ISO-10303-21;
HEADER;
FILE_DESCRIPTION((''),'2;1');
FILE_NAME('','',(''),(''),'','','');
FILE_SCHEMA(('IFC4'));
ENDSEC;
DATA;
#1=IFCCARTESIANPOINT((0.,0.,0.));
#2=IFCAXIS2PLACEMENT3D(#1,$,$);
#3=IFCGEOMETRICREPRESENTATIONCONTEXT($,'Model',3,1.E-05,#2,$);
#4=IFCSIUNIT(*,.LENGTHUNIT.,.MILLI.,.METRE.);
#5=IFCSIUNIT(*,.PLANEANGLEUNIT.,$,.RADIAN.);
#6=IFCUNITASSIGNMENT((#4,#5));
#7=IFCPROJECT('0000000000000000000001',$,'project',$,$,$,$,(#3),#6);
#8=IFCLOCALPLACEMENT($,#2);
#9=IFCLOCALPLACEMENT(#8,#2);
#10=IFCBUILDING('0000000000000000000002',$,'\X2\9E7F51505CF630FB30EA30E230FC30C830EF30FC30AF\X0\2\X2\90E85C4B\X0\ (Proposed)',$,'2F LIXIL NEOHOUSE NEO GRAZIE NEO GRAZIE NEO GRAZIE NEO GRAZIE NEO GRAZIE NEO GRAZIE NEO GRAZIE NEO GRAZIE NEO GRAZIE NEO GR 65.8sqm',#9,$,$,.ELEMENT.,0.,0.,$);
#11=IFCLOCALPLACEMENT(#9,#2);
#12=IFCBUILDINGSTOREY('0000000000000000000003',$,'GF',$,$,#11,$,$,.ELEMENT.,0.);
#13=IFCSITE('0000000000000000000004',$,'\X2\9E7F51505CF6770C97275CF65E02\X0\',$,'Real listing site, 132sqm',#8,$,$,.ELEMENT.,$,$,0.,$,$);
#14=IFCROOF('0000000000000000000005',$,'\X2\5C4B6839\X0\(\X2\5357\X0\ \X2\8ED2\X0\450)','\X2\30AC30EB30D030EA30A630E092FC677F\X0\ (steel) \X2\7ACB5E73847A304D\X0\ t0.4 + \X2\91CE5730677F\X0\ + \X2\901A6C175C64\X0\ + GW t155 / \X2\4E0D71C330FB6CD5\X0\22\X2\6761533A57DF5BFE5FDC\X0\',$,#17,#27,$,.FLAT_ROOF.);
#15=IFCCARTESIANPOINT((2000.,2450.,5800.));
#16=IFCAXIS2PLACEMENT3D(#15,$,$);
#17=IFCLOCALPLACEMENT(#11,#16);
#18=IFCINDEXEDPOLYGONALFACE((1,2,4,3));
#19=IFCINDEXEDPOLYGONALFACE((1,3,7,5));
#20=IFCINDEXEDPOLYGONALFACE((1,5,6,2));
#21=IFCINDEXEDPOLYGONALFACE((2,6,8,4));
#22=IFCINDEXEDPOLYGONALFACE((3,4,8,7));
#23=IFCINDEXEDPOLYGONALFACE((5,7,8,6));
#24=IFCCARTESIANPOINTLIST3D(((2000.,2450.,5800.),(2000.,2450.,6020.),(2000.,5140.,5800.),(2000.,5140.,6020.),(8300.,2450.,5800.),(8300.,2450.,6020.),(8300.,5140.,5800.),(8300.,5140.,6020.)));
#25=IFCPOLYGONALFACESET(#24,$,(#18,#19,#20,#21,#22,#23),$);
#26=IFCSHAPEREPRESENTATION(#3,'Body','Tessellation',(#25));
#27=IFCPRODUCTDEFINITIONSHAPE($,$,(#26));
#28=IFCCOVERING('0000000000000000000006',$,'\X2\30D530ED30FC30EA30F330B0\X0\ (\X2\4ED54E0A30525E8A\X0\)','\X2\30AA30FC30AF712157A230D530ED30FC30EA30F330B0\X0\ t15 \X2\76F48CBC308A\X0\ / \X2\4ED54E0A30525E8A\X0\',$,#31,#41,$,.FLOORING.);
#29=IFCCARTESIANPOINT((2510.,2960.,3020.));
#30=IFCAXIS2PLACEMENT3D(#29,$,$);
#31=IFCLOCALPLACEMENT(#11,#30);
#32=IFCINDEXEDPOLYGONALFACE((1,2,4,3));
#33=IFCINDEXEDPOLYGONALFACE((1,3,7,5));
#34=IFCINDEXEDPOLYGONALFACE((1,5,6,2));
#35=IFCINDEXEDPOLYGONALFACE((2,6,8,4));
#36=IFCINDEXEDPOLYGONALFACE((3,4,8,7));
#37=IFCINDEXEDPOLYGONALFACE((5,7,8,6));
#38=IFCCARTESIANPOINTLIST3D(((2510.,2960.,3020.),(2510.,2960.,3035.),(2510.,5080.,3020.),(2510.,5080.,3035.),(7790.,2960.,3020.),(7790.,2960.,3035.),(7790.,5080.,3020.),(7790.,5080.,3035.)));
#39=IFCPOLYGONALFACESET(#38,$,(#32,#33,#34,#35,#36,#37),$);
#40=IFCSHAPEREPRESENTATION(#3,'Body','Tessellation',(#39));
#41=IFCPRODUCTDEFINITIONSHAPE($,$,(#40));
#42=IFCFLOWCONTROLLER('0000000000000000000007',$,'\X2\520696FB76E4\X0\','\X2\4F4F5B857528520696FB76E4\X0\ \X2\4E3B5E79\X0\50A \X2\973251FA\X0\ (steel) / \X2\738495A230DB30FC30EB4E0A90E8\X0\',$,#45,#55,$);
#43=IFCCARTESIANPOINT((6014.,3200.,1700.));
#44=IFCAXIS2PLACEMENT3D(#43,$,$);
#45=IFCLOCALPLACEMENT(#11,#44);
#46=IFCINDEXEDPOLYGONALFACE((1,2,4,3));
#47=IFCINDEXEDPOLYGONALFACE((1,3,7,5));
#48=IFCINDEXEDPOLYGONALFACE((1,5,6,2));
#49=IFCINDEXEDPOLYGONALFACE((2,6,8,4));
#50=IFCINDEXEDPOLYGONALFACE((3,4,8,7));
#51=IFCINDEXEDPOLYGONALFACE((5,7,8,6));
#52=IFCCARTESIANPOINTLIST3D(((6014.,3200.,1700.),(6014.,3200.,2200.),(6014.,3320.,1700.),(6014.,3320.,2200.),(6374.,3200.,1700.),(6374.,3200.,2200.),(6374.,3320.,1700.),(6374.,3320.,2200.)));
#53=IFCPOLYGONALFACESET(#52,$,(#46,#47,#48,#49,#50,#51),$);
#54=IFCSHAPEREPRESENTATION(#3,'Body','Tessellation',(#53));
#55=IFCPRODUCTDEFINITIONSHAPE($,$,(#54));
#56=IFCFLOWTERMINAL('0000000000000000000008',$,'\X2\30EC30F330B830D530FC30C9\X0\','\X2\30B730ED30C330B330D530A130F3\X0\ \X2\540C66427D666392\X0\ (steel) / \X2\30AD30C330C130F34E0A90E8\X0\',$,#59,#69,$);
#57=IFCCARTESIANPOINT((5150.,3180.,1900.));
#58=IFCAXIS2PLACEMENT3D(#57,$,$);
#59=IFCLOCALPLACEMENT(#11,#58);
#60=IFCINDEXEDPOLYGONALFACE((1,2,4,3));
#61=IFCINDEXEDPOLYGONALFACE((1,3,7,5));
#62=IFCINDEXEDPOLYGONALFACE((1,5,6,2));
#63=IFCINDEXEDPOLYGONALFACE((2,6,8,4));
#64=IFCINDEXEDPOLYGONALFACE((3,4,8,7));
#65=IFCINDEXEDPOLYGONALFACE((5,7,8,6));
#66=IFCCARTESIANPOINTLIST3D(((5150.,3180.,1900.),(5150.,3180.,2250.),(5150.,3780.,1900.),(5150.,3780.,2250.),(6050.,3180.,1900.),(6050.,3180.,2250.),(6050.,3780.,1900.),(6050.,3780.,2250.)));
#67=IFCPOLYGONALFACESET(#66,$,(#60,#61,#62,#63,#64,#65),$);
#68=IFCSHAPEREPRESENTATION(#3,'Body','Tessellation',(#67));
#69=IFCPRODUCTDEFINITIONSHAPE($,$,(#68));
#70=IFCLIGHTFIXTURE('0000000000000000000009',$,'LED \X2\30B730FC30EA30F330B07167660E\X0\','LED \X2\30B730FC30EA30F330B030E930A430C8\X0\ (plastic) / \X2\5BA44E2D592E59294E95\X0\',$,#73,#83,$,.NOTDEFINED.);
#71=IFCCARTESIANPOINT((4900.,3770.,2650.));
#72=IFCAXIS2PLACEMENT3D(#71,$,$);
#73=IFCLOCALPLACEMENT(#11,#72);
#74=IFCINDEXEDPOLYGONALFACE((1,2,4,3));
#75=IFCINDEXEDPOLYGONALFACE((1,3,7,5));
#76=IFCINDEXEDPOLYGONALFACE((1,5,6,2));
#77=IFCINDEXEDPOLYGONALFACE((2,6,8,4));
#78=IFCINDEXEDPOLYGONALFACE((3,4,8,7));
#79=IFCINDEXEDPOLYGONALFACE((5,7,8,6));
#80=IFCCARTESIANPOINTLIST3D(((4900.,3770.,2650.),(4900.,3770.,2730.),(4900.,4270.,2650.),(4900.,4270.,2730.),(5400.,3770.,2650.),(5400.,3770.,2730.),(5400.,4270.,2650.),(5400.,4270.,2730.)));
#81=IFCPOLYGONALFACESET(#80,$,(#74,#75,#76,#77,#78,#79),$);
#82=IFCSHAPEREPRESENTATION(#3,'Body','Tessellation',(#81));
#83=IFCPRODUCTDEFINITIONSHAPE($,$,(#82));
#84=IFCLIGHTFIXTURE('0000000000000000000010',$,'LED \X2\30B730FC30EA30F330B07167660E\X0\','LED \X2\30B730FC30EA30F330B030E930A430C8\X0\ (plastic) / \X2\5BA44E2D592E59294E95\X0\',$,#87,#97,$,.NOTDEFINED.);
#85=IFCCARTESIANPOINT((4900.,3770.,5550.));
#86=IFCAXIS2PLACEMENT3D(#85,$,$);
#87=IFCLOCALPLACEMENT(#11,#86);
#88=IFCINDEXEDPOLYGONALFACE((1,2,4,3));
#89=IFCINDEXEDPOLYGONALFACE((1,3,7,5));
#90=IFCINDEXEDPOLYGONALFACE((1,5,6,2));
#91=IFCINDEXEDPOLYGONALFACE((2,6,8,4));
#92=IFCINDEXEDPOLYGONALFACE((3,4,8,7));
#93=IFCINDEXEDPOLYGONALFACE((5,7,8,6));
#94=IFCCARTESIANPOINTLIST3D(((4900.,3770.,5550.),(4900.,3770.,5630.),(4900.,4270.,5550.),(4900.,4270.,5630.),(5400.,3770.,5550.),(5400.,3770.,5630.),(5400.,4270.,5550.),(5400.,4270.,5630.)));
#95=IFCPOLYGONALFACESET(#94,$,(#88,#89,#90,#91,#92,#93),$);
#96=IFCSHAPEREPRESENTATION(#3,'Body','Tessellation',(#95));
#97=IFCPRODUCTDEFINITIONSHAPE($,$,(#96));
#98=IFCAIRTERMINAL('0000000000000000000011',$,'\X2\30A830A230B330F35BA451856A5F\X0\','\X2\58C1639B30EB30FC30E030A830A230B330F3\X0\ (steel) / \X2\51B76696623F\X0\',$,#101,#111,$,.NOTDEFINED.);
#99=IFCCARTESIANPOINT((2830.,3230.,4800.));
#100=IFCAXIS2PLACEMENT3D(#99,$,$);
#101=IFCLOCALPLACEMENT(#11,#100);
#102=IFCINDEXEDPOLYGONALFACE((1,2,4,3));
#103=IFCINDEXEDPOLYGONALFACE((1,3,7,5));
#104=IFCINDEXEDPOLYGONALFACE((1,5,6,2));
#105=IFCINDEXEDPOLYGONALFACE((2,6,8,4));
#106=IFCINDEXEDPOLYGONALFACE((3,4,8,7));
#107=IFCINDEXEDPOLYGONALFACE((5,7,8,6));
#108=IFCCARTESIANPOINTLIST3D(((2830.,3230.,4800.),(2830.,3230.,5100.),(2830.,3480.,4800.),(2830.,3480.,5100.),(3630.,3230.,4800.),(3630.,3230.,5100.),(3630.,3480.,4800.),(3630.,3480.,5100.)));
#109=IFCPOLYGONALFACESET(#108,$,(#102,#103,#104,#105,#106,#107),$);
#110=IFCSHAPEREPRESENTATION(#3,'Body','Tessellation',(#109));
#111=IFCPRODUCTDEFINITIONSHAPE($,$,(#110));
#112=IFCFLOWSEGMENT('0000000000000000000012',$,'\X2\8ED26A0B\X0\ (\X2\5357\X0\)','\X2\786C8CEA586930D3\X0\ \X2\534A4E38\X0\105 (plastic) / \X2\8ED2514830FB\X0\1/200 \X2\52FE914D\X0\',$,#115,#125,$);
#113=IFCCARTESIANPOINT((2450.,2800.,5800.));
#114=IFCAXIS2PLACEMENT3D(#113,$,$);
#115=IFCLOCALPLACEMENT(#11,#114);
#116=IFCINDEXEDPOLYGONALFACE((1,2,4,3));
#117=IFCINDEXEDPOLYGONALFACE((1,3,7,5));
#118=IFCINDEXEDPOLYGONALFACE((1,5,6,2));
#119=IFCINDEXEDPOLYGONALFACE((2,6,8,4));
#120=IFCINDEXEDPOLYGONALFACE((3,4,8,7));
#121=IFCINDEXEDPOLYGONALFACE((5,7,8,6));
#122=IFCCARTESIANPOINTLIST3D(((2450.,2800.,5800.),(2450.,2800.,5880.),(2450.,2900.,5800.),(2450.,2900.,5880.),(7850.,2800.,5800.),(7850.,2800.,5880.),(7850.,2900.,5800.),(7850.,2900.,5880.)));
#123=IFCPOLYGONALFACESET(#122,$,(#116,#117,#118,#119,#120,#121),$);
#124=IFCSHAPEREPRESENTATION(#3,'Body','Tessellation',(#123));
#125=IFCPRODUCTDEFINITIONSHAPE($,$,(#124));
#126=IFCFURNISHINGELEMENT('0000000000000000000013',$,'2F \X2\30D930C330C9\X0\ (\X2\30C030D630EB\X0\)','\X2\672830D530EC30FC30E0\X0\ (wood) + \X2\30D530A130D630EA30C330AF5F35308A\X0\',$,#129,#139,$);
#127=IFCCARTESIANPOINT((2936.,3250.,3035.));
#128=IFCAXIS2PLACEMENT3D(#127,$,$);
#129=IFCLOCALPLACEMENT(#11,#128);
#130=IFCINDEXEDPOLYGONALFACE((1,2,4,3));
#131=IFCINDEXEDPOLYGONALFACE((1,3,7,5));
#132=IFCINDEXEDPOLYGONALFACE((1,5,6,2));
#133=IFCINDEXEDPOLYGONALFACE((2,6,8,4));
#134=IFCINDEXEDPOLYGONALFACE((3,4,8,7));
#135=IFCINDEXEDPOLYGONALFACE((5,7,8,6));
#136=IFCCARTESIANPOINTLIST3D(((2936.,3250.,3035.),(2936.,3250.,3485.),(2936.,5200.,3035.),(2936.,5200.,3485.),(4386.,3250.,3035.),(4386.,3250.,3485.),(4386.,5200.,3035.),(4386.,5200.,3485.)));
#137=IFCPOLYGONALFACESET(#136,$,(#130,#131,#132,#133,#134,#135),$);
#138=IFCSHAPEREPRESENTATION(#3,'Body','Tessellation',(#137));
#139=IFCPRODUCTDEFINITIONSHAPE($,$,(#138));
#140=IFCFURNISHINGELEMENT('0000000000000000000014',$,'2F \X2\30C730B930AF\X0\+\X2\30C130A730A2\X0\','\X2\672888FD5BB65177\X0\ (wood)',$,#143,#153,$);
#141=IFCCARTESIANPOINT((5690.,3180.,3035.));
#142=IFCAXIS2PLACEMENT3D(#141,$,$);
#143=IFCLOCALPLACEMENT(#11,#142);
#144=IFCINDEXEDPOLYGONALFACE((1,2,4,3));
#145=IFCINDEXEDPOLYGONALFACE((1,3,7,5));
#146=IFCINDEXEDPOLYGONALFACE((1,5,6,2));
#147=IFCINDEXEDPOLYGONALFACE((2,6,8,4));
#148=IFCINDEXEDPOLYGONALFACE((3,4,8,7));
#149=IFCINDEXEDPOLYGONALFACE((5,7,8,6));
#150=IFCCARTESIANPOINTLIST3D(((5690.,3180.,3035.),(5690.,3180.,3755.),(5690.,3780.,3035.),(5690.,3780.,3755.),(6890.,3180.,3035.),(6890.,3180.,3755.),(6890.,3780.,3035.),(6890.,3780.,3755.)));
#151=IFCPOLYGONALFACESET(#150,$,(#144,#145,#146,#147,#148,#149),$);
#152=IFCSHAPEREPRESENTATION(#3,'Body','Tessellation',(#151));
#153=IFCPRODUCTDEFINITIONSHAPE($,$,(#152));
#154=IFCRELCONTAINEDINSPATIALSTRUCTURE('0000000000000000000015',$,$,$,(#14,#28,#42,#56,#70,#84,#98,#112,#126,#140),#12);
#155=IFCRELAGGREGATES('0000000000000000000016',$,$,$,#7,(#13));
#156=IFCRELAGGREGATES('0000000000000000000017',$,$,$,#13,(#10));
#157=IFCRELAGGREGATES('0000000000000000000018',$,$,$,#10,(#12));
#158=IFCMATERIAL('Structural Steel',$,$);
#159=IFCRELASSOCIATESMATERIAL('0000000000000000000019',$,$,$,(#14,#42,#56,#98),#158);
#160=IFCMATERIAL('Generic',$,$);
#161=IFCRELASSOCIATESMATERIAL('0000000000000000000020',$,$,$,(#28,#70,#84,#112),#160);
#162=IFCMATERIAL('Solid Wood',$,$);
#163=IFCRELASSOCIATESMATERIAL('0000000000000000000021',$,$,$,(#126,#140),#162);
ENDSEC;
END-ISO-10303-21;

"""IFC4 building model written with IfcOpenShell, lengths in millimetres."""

from ifc_helpers import new_model, si_unit, frame, frame_2d, origin, place, context, project, spatial, rectangle, extrude, material, element, save


model = new_model("IFC4")

# Units and contexts
model_context = context("Model", 3, precision=1e-05, world=origin())
ifc_project = project(units=[si_unit("LENGTHUNIT", "METRE", prefix="MILLI"), si_unit("PLANEANGLEUNIT", "RADIAN")], contexts=[model_context])

# Site, building, storey
site_placement = place(None, origin())
site = spatial("IfcSite", under=ifc_project, at=site_placement, Name="鹿児島県霧島市", ObjectType="Real listing site, 132sqm", CompositionType="ELEMENT", RefElevation=0.0)
building_placement = place(site_placement, origin())
building = spatial("IfcBuilding", under=site, at=building_placement, Name="鹿児島・リモートワーク2部屋 (Proposed)", ObjectType="2F LIXIL NEOHOUSE NEO GRAZIE NEO GRAZIE NEO GRAZIE NEO GRAZIE NEO GRAZIE NEO GRAZIE NEO GRAZIE NEO GRAZIE NEO GRAZIE NEO GR 65.8sqm", CompositionType="ELEMENT", ElevationOfRefHeight=0.0, ElevationOfTerrain=0.0)
storey_placement = place(building_placement, origin())
storey = spatial("IfcBuildingStorey", under=building, at=storey_placement, Name="GF", CompositionType="ELEMENT", Elevation=0.0)

# Shared definitions
ifc_material_1 = material(Name="Solid Wood")

# Roof
ifc_material_2 = material(Name="Structural Steel")
for number, where, name in (
    (1, (2000.0, 2450.0, 5800.0), "屋根(南 軒450)"),
):
    element("IfcRoof", number, at=place(storey_placement, frame(where)), inside=storey, material=ifc_material_2, Name=name, Description="ガルバリウム鋼板 (steel) 立平葺き t0.4 + 野地板 + 通気層 + GW t155 / 不燃・法22条区域対応", PredefinedType="FLAT_ROOF", context=model_context, shape_type="SweptSolid", body=[
        extrude(rectangle(XDim=6300.0, YDim=2690.0, at=frame_2d((3150.0, 1345.0))), frame((2000.0, 2450.0, 5800.0)), (0.0, 0.0, 1.0), 220.0),
    ])

# Covering
ifc_material_3 = material(Name="Generic")
covering_placement = place(storey_placement, frame((2510.0, 2960.0, 3020.0)))
element("IfcCovering", 2, at=covering_placement, inside=storey, material=ifc_material_3, Name="フローリング (仕上げ床)", Description="オーク無垢フローリング t15 直貼り / 仕上げ床", PredefinedType="FLOORING", context=model_context, shape_type="SweptSolid", body=[
    extrude(rectangle(XDim=5280.0, YDim=2120.0, at=frame_2d((2640.0, 1060.0))), frame((2510.0, 2960.0, 3020.0)), (0.0, 0.0, 1.0), 15.0),
])

# Flow controller
flow_controller_placement = place(storey_placement, frame((6014.0, 3200.0, 1700.0)))
element("IfcFlowController", 3, at=flow_controller_placement, inside=storey, material=ifc_material_2, Name="分電盤", Description="住宅用分電盤 主幹50A 露出 (steel) / 玄関ホール上部", context=model_context, shape_type="SweptSolid", body=[
    extrude(rectangle(XDim=360.0, YDim=120.0, at=frame_2d((180.0, 60.0))), frame((6014.0, 3200.0, 1700.0)), (0.0, 0.0, 1.0), 500.0),
])

# Flow terminal
flow_terminal_placement = place(storey_placement, frame((5150.0, 3180.0, 1900.0)))
element("IfcFlowTerminal", 4, at=flow_terminal_placement, inside=storey, material=ifc_material_2, Name="レンジフード", Description="シロッコファン 同時給排 (steel) / キッチン上部", context=model_context, shape_type="SweptSolid", body=[
    extrude(rectangle(XDim=900.0, YDim=600.0, at=frame_2d((450.0, 300.0))), frame((5150.0, 3180.0, 1900.0)), (0.0, 0.0, 1.0), 350.0),
])

# Light fixtures
light_fixture_1_placement = place(storey_placement, frame((4900.0, 3770.0, 2650.0)))
element("IfcLightFixture", 5, at=light_fixture_1_placement, inside=storey, material=ifc_material_3, Name="LED シーリング照明", Description="LED シーリングライト (plastic) / 室中央天井", PredefinedType="NOTDEFINED", context=model_context, shape_type="SweptSolid", body=[
    extrude(rectangle(XDim=500.0, YDim=500.0, at=frame_2d((250.0, 250.0))), frame((4900.0, 3770.0, 2650.0)), (0.0, 0.0, 1.0), 80.0),
])
light_fixture_2_placement = place(storey_placement, frame((4900.0, 3770.0, 5550.0)))
element("IfcLightFixture", 6, at=light_fixture_2_placement, inside=storey, material=ifc_material_3, Name="LED シーリング照明", Description="LED シーリングライト (plastic) / 室中央天井", PredefinedType="NOTDEFINED", context=model_context, shape_type="SweptSolid", body=[
    extrude(rectangle(XDim=500.0, YDim=500.0, at=frame_2d((250.0, 250.0))), frame((4900.0, 3770.0, 5550.0)), (0.0, 0.0, 1.0), 80.0),
])

# Air terminal
air_terminal_placement = place(storey_placement, frame((2830.0, 3230.0, 4800.0)))
element("IfcAirTerminal", 7, at=air_terminal_placement, inside=storey, material=ifc_material_2, Name="エアコン室内機", Description="壁掛ルームエアコン (steel) / 冷暖房", PredefinedType="NOTDEFINED", context=model_context, shape_type="SweptSolid", body=[
    extrude(rectangle(XDim=800.0, YDim=250.0, at=frame_2d((400.0, 125.0))), frame((2830.0, 3230.0, 4800.0)), (0.0, 0.0, 1.0), 300.0),
])

# Flow segment
flow_segment_placement = place(storey_placement, frame((2450.0, 2800.0, 5800.0)))
element("IfcFlowSegment", 8, at=flow_segment_placement, inside=storey, material=ifc_material_3, Name="軒樋 (南)", Description="硬質塩ビ 半丸105 (plastic) / 軒先・1/200 勾配", context=model_context, shape_type="SweptSolid", body=[
    extrude(rectangle(XDim=5400.0, YDim=100.0, at=frame_2d((2700.0, 50.0))), frame((2450.0, 2800.0, 5800.0)), (0.0, 0.0, 1.0), 80.0),
])

# Furnishing elements
furnishing_1_placement = place(storey_placement, frame((2936.0, 3250.0, 3035.0)))
element("IfcFurnishingElement", 9, at=furnishing_1_placement, inside=storey, material=ifc_material_1, Name="2F ベッド (ダブル)", Description="木フレーム (wood) + ファブリック張り", context=model_context, shape_type="SweptSolid", body=[
    extrude(rectangle(XDim=1450.0, YDim=1950.0, at=frame_2d((725.0, 975.0))), frame((2936.0, 3250.0, 3035.0)), (0.0, 0.0, 1.0), 450.0),
])
furnishing_2_placement = place(storey_placement, frame((5690.0, 3180.0, 3035.0)))
element("IfcFurnishingElement", 10, at=furnishing_2_placement, inside=storey, material=ifc_material_1, Name="2F デスク+チェア", Description="木製家具 (wood)", context=model_context, shape_type="SweptSolid", body=[
    extrude(rectangle(XDim=1200.0, YDim=600.0, at=frame_2d((600.0, 300.0))), frame((5690.0, 3180.0, 3035.0)), (0.0, 0.0, 1.0), 720.0),
])

save(model, "model.ifc")
